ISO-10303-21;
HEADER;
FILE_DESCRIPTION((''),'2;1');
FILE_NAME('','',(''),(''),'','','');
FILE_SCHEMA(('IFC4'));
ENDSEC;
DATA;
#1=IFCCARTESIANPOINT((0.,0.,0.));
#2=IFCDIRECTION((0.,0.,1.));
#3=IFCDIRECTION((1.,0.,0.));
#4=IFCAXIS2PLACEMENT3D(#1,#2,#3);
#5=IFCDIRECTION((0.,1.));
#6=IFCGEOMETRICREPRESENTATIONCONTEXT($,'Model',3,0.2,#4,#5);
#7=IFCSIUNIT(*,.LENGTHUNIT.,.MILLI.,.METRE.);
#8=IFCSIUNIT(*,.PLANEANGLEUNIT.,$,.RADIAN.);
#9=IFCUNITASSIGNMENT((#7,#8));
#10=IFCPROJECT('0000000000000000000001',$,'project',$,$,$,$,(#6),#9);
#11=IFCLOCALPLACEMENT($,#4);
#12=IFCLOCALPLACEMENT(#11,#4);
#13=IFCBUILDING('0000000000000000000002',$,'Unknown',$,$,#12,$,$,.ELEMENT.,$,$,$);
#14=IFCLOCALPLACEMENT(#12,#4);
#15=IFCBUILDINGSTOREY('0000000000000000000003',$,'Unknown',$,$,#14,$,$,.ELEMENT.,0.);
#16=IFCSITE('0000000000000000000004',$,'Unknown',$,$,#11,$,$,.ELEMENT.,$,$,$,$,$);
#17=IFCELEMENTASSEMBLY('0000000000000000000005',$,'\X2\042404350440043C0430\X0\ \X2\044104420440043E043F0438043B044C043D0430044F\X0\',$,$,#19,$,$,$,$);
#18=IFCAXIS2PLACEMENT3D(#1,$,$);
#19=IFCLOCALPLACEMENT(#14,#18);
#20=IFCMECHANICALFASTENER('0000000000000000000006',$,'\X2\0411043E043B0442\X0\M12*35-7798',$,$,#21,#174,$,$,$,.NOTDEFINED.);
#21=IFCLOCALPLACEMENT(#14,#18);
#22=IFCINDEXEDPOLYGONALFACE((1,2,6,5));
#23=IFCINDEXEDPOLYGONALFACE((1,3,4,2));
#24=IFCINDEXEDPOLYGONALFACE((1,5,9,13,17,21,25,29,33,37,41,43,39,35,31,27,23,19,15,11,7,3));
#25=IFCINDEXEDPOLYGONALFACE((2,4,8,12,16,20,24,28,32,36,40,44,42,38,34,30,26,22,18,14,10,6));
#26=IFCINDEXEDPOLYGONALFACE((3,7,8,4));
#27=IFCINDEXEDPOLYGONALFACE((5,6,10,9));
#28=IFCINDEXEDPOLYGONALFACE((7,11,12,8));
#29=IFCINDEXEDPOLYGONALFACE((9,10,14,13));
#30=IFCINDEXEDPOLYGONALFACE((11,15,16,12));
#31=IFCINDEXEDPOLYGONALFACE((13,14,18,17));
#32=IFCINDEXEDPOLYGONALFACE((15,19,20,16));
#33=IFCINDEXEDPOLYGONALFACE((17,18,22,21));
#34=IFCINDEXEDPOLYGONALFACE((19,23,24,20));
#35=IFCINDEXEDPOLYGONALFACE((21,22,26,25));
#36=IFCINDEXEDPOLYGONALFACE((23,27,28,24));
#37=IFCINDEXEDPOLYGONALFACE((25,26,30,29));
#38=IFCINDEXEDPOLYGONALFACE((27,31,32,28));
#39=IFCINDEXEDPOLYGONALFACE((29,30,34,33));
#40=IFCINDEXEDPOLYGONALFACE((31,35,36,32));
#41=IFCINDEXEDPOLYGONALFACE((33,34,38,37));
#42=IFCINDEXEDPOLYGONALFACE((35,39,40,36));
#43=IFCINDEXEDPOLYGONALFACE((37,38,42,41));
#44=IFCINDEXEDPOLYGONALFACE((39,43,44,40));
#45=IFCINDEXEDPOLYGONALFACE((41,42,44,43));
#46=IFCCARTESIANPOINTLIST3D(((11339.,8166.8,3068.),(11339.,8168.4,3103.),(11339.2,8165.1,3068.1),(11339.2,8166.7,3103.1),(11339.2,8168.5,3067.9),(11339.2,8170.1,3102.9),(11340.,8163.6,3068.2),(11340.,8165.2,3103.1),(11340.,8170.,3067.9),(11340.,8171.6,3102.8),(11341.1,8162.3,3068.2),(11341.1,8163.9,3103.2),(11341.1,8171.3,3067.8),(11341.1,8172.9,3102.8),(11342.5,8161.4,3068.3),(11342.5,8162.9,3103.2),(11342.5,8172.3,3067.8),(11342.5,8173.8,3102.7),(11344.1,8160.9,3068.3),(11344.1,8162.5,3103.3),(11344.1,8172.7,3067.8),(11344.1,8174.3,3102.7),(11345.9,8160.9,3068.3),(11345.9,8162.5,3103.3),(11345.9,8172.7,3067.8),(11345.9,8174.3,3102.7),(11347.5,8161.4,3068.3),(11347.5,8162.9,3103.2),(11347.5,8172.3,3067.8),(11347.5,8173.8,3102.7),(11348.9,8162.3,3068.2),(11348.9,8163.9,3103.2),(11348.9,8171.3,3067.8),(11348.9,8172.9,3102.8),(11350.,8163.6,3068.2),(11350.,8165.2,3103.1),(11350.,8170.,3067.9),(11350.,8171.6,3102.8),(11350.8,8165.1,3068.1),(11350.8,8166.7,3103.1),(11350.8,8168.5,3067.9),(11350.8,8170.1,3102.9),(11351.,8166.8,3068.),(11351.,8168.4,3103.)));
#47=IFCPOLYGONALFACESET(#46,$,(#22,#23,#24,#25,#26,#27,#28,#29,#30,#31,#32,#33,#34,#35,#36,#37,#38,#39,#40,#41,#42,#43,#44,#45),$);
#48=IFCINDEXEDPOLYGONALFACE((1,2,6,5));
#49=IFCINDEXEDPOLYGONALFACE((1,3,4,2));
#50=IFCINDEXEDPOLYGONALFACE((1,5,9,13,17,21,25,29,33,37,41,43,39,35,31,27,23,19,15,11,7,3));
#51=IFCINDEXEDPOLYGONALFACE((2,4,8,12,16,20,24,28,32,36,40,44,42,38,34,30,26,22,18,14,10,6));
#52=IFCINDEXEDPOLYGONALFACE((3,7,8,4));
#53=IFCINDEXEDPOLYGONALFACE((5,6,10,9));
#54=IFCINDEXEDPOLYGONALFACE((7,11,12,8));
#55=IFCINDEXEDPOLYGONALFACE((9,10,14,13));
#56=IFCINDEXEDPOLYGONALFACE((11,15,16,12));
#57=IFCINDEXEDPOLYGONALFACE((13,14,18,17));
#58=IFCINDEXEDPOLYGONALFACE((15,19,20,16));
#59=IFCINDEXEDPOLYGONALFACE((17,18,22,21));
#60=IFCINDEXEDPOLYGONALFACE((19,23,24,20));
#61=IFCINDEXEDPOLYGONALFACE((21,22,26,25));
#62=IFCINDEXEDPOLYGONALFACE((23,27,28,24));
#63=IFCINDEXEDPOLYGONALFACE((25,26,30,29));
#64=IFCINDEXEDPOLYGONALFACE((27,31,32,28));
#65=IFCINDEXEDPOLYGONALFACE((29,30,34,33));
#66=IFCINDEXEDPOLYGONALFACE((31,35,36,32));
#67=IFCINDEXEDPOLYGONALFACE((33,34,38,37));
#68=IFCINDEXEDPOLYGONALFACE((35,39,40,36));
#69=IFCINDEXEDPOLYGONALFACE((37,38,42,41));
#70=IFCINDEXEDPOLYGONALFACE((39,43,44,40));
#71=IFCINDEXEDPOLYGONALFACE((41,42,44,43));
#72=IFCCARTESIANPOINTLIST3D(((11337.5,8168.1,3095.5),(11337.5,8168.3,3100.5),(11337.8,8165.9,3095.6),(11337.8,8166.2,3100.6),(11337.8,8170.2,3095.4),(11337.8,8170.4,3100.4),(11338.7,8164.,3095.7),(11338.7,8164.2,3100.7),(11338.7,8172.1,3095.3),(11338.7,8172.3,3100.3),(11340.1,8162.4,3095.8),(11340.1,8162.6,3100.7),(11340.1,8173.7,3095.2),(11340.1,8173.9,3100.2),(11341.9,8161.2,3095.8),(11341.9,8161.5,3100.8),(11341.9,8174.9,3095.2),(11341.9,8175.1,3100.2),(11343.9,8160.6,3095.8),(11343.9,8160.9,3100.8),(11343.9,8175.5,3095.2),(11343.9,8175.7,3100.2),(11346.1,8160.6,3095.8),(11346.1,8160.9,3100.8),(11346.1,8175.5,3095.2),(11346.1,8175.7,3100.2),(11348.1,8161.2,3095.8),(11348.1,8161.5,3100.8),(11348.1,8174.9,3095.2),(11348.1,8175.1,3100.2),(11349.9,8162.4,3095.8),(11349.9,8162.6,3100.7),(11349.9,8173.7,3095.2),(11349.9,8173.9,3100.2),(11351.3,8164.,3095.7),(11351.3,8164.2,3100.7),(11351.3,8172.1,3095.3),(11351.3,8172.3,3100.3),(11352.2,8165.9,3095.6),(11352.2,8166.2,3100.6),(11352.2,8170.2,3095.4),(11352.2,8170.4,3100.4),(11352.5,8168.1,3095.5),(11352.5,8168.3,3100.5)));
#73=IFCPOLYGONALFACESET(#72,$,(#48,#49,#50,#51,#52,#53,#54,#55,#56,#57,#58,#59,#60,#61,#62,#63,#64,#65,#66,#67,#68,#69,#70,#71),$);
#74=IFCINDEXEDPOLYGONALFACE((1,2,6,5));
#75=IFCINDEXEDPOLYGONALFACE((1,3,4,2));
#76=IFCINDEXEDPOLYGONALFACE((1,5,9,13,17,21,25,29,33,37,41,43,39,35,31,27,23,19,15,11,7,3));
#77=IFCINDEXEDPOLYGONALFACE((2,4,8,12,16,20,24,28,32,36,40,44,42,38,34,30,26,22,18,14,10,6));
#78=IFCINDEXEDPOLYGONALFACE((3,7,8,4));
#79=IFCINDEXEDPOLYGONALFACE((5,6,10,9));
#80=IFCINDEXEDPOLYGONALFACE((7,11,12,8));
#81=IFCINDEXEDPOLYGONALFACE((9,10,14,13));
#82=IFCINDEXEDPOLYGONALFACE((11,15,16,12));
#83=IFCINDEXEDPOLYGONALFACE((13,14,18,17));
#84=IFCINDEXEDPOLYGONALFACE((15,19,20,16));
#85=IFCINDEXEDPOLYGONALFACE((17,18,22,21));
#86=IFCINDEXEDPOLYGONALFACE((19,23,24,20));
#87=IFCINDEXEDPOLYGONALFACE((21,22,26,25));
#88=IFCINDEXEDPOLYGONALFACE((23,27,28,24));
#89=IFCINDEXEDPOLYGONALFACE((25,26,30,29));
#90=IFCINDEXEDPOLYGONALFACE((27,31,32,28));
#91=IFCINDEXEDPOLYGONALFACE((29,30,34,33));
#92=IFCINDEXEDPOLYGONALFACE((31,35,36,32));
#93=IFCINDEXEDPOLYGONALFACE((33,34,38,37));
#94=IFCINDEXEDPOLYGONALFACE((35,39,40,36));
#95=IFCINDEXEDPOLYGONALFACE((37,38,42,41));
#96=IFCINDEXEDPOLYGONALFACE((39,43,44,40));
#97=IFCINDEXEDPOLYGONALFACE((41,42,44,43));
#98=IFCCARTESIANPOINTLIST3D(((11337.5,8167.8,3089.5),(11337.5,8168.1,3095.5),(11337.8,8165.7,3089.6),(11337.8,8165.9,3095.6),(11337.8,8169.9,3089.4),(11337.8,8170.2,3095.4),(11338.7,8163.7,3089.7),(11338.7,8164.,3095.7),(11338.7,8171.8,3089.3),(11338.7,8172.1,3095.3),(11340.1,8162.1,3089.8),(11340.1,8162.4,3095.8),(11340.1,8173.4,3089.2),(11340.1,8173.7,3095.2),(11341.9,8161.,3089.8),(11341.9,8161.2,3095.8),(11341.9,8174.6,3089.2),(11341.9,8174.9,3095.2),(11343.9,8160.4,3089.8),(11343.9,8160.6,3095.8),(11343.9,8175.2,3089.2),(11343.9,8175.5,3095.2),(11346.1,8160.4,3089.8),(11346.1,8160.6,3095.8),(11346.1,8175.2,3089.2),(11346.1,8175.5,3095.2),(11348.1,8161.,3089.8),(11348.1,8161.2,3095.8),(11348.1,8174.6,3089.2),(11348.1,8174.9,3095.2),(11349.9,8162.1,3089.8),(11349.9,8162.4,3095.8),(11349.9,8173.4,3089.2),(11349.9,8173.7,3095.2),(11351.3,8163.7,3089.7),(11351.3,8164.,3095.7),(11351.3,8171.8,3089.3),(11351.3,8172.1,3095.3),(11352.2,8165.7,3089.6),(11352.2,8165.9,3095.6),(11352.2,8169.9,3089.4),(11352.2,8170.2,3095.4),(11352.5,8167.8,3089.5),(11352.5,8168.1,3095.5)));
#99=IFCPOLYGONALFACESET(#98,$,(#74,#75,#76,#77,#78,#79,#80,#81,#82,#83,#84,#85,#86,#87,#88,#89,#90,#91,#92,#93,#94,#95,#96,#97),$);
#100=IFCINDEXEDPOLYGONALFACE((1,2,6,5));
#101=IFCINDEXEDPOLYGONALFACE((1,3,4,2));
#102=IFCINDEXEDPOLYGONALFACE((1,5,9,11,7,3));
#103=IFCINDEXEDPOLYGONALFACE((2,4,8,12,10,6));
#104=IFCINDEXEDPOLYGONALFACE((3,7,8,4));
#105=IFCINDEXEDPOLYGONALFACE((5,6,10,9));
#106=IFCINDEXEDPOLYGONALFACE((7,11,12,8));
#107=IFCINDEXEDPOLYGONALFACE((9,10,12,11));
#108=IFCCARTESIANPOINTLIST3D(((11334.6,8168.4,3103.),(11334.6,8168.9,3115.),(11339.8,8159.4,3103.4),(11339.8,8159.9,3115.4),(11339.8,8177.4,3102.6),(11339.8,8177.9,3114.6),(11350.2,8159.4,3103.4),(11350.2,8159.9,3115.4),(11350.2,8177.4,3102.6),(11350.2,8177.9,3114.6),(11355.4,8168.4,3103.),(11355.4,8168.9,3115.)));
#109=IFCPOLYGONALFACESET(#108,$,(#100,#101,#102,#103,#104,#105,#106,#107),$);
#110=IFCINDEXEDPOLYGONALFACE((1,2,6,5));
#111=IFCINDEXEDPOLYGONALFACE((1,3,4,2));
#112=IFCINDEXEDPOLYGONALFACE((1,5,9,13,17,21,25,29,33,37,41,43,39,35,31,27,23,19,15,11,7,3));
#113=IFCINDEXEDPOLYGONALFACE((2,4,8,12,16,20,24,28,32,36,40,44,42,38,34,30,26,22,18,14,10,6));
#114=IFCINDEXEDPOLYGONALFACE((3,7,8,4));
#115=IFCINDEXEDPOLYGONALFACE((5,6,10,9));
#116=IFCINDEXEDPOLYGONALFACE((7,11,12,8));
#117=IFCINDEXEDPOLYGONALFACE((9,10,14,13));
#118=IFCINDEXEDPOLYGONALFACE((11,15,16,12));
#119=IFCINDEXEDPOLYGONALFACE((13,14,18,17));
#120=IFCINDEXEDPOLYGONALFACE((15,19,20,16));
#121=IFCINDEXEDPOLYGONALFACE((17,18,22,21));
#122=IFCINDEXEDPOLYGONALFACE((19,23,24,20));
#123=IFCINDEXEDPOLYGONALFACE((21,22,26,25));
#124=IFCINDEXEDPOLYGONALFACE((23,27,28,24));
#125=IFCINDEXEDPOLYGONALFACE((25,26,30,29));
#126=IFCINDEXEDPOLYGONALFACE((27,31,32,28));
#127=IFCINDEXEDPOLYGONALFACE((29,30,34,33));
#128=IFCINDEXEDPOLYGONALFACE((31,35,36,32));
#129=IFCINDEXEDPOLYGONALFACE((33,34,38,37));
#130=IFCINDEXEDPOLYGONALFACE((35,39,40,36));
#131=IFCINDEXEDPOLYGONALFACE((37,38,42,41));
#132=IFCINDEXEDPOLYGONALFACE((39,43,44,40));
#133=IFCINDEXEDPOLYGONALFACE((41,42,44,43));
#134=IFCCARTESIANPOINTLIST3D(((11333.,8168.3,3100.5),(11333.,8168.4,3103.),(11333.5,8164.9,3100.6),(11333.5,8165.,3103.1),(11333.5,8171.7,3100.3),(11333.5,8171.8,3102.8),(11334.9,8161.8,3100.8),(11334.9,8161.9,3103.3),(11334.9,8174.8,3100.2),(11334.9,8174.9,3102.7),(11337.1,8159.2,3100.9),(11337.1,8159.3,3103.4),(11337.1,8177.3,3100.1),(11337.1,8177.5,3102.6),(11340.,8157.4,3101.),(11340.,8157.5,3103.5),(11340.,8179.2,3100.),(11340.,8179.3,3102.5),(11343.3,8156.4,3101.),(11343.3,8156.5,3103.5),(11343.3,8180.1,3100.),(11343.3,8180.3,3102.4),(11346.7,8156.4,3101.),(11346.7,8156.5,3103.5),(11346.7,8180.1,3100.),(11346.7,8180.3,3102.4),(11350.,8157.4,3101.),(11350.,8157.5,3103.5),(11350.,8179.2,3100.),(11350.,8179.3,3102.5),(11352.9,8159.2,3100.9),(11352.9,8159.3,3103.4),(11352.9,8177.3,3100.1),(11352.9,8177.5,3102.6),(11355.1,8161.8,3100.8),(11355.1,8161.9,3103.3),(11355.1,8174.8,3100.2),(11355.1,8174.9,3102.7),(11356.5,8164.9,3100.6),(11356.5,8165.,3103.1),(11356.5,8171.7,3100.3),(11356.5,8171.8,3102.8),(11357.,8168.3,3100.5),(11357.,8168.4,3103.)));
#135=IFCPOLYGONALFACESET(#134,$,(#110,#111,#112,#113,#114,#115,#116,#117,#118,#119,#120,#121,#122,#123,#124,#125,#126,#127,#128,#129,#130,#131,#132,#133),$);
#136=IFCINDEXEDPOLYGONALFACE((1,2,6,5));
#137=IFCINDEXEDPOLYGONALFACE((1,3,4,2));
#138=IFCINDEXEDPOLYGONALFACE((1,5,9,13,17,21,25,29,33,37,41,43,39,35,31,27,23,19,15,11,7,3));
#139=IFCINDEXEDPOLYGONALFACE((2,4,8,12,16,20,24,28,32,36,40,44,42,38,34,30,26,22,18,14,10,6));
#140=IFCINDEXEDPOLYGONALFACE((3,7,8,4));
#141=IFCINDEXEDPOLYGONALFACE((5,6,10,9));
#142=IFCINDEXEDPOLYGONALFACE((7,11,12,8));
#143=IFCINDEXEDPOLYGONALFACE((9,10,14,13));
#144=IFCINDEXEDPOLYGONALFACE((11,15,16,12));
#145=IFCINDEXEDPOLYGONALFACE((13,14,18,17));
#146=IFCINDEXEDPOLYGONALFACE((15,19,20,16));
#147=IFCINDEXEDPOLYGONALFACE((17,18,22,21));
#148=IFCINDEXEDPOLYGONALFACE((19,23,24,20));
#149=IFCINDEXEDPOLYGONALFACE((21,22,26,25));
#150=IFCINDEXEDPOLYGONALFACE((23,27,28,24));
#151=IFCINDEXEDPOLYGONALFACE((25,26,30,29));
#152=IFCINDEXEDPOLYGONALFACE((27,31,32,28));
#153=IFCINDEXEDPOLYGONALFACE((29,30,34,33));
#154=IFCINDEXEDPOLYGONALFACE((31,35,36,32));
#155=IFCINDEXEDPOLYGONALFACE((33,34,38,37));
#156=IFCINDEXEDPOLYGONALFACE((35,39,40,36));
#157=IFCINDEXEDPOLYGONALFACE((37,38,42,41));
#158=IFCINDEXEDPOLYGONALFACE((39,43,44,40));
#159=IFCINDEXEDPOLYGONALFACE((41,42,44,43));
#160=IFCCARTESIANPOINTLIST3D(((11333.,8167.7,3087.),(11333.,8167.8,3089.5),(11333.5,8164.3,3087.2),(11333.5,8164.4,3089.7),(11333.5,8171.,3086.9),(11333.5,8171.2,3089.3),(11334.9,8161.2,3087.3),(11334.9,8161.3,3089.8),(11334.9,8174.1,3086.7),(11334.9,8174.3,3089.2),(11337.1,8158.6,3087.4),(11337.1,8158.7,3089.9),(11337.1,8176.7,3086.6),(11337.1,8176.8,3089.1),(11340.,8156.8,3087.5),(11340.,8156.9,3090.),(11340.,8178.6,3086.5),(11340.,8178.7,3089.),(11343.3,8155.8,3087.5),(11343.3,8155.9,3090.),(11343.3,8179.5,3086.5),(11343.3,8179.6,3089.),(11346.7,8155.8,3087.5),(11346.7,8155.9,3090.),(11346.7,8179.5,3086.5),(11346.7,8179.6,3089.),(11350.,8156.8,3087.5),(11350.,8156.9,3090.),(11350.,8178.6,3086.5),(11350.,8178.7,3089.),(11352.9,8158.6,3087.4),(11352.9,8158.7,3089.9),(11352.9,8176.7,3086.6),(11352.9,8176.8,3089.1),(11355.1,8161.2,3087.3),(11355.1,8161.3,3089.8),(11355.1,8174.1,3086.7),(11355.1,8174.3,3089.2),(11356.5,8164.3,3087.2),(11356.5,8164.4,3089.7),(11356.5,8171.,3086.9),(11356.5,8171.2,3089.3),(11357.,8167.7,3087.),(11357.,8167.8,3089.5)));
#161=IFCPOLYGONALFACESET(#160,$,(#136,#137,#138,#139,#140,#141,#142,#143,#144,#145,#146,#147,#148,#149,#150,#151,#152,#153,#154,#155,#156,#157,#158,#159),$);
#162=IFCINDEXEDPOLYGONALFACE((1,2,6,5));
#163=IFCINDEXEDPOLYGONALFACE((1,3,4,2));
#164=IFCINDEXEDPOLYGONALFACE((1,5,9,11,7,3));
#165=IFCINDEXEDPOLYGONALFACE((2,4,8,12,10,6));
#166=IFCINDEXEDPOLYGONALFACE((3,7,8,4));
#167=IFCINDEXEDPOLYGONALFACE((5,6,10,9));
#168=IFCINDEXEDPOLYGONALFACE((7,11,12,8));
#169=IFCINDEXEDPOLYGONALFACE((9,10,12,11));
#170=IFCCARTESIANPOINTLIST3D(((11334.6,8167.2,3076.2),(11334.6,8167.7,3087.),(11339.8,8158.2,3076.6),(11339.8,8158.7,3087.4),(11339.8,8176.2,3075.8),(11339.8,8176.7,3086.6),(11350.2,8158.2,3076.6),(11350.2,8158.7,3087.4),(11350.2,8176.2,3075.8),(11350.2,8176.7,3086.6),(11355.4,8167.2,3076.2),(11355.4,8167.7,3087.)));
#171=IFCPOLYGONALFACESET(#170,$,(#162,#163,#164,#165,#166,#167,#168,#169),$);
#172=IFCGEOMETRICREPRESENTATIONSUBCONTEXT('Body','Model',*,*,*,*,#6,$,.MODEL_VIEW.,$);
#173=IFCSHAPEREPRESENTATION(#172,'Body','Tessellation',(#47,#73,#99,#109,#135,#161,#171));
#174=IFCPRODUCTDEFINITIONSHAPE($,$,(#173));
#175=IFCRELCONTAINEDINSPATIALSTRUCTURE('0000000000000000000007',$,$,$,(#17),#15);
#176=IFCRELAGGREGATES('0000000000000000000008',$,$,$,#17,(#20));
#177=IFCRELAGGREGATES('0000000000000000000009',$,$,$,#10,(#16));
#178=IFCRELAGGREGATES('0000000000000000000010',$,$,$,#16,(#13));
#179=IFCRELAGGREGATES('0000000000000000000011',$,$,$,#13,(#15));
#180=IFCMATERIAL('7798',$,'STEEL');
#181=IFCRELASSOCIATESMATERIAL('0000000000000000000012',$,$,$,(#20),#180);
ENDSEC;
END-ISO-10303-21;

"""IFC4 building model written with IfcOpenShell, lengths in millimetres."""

from ifc_helpers import new_model, si_unit, direction, frame, origin_with_axes, place, context, subcontext, project, spatial, line, arc, indexed_curve, outline, extrude, source, transform, mapped, material, element, aggregate, save


model = new_model("IFC4")

# Units and contexts
model_context = context("Model", 3, precision=0.2, world=origin_with_axes(), true_north=direction((0.0, 1.0)))
body_context = subcontext(model_context, "Body", "Model", "MODEL_VIEW")
ifc_project = project(units=[si_unit("LENGTHUNIT", "METRE", prefix="MILLI"), si_unit("PLANEANGLEUNIT", "RADIAN")], contexts=[model_context])

# Site, building, storey
site_placement = place(None, origin_with_axes())
site = spatial("IfcSite", under=ifc_project, at=site_placement, Name="Unknown", CompositionType="ELEMENT")
building_placement = place(site_placement, origin_with_axes())
building = spatial("IfcBuilding", under=site, at=building_placement, Name="Unknown", CompositionType="ELEMENT")
storey_placement = place(building_placement, origin_with_axes())
storey = spatial("IfcBuildingStorey", under=building, at=storey_placement, Name="Unknown", CompositionType="ELEMENT", Elevation=0.0)

# Element assembly
assembly_1_placement = place(storey_placement, frame((11400.0, 88.6, 3426.7), z_axis=(1.0, 0.0, 0.0), x_axis=(0.0, 0.998969, -0.045408)))
assembly_1 = element("IfcElementAssembly", 1, at=assembly_1_placement, inside=storey, Name="Ферма стропильная")

# Mechanical fastener
ifc_material_1 = material(Name="7798", Category="STEEL")
shared_shape_1 = source(origin_with_axes(), body_context, "Body", "SweptSolid", [
    extrude(outline(indexed_curve([(6.0, 0.0), (0.0, 6.0), (-6.0, 0.0), (0.0, -6.0)], segments=[arc(1, 2, 3), arc(3, 4, 1)])), frame((0.0, 0.0, 7.5), z_axis=(0.0, 0.0, -1.0), x_axis=(0.0, 1.0, 0.0)), (0.0, 0.0, 1.0), 35.0),
    extrude(outline(indexed_curve([(7.5, 0.0), (0.0, 7.5), (-7.5, 0.0), (0.0, -7.5)], segments=[arc(1, 2, 3), arc(3, 4, 1)])), frame((0.0, 0.0, 5.0), z_axis=(0.0, 0.0, -1.0), x_axis=(0.0, 1.0, 0.0)), (0.0, 0.0, 1.0), 5.0),
    extrude(outline(indexed_curve([(7.5, 0.0), (0.0, 7.5), (-7.5, 0.0), (0.0, -7.5)], segments=[arc(1, 2, 3), arc(3, 4, 1)])), frame((0.0, 0.0, 0.0), z_axis=(0.0, 0.0, -1.0), x_axis=(0.0, 1.0, 0.0)), (0.0, 0.0, 1.0), 6.0),
    extrude(outline(indexed_curve([(10.4, 0.0), (5.2, 9.0), (-5.2, 9.0), (-10.4, 0.0), (-5.2, -9.0), (5.2, -9.0)], segments=[line(1, 2, 3, 4, 5, 6, 1)])), frame((0.0, 0.0, 19.5), z_axis=(0.0, 0.0, -1.0), x_axis=(0.0, 1.0, 0.0)), (0.0, 0.0, 1.0), 12.0),
    extrude(outline(indexed_curve([(12.0, 0.0), (0.0, 12.0), (-12.0, 0.0), (0.0, -12.0)], segments=[arc(1, 2, 3), arc(3, 4, 1)])), frame((0.0, 0.0, 7.5), z_axis=(0.0, 0.0, -1.0), x_axis=(0.0, 1.0, 0.0)), (0.0, 0.0, 1.0), 2.5),
    extrude(outline(indexed_curve([(12.0, 0.0), (0.0, 12.0), (-12.0, 0.0), (0.0, -12.0)], segments=[arc(1, 2, 3), arc(3, 4, 1)])), frame((0.0, 0.0, -6.0), z_axis=(0.0, 0.0, -1.0), x_axis=(0.0, 1.0, 0.0)), (0.0, 0.0, 1.0), 2.5),
    extrude(outline(indexed_curve([(10.4, 0.0), (5.2, 9.0), (-5.2, 9.0), (-10.4, 0.0), (-5.2, -9.0), (5.2, -9.0)], segments=[line(1, 2, 3, 4, 5, 6, 1)])), frame((0.0, 0.0, -8.5), z_axis=(0.0, 0.0, -1.0), x_axis=(0.0, 1.0, 0.0)), (0.0, 0.0, 1.0), 10.8),
])
mechanical_fastener_1_placement = place(assembly_1_placement, frame((8086.1, 36.0, -55.0), z_axis=(0.0, 1.0, 0.0), x_axis=(1.0, 0.0, 0.0)))
mechanical_fastener_1 = element("IfcMechanicalFastener", 2, at=mechanical_fastener_1_placement, material=ifc_material_1, Name="БолтM12*35-7798", PredefinedType="NOTDEFINED", context=body_context, shape_type="MappedRepresentation", body=[
    mapped(shared_shape_1, transform((0.0, 0.0, 0.0))),
])
aggregate(assembly_1, [mechanical_fastener_1])

save(model, "model.ifc")
